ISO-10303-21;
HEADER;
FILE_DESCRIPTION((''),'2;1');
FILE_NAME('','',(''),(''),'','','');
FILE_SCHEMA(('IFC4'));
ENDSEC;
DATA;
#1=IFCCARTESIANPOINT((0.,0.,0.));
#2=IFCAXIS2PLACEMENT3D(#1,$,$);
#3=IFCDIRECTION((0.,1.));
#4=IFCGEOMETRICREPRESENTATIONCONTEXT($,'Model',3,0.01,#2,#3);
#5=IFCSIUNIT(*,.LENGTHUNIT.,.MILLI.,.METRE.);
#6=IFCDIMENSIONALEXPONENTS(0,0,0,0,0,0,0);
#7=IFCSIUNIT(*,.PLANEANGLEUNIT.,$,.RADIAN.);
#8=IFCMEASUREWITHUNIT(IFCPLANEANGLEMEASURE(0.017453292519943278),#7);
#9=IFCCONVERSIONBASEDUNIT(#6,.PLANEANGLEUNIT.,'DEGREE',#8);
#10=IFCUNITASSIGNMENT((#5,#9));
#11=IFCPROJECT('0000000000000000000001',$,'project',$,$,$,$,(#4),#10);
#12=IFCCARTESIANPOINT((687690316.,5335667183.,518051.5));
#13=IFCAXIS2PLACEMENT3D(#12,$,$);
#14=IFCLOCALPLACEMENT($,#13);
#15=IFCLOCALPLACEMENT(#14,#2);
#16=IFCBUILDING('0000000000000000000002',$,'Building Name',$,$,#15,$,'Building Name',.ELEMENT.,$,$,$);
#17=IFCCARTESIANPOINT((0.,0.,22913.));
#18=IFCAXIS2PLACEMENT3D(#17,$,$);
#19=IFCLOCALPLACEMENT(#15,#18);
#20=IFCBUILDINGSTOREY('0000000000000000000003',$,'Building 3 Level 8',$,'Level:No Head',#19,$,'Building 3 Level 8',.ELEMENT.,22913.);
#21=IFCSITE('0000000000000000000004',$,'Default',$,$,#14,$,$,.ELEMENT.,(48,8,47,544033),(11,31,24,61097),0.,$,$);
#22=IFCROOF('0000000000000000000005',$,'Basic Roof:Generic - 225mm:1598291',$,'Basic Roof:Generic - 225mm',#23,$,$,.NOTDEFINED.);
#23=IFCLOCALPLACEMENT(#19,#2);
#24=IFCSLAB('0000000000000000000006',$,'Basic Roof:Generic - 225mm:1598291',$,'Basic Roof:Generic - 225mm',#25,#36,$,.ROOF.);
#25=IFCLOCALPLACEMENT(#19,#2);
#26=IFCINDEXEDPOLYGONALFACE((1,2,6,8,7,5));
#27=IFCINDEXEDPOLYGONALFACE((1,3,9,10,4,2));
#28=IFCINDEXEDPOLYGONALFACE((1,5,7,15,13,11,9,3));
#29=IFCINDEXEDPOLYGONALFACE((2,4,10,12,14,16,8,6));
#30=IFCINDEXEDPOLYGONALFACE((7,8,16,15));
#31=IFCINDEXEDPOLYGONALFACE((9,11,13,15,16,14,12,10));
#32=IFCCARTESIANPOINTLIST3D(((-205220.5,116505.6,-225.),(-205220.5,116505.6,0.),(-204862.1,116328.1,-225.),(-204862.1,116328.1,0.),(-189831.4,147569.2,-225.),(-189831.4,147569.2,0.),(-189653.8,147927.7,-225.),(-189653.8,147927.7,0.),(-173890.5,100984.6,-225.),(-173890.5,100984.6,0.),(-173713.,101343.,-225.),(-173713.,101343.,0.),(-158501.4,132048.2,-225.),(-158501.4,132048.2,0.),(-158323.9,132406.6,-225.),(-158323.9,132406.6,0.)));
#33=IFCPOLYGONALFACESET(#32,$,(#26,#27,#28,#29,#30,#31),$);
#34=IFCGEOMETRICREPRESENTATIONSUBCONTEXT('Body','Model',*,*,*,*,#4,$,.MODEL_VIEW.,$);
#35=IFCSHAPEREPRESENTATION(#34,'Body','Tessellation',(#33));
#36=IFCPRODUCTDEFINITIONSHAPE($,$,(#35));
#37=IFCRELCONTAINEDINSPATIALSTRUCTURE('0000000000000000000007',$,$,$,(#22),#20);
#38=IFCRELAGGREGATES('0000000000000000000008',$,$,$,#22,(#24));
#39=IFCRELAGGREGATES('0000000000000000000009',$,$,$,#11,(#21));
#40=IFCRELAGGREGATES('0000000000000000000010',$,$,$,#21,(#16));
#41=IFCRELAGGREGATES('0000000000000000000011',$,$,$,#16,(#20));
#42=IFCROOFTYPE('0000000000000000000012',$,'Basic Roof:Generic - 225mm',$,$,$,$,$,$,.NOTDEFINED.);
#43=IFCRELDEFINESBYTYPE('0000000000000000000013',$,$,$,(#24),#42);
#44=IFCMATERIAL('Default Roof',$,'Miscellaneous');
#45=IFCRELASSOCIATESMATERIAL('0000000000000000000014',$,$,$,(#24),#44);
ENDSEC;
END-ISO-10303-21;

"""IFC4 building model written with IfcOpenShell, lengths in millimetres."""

from ifc_helpers import new_model, entity, si_unit, converted_unit, direction, frame, origin, place, context, subcontext, project, spatial, indexed_curve, outline, extrude, material, type_object, element, aggregate, save


model = new_model("IFC4")

# Units and contexts
model_context = context("Model", 3, precision=0.01, world=origin(), true_north=direction((0.0, 1.0)))
body_context = subcontext(model_context, "Body", "Model", "MODEL_VIEW")
ifc_project = project(units=[si_unit("LENGTHUNIT", "METRE", prefix="MILLI"), converted_unit("PLANEANGLEUNIT", "DEGREE", entity("IfcPlaneAngleMeasure", 0.017453292519943278), si_unit("PLANEANGLEUNIT", "RADIAN"), dimensions=[0, 0, 0, 0, 0, 0, 0])], contexts=[model_context])

# Site, building, storey
site_placement = place(None, frame((687690316.0, 5335667183.0, 518051.5)))
site = spatial("IfcSite", under=ifc_project, at=site_placement, Name="Default", CompositionType="ELEMENT", RefLatitude=(48, 8, 47, 544033), RefLongitude=(11, 31, 24, 61097), RefElevation=0.0)
building_placement = place(site_placement, origin())
building = spatial("IfcBuilding", under=site, at=building_placement, Name="Building Name", LongName="Building Name", CompositionType="ELEMENT")
storey_placement = place(building_placement, frame((0.0, 0.0, 22913.0)))
storey = spatial("IfcBuildingStorey", under=building, at=storey_placement, Name="Building 3 Level 8", ObjectType="Level:No Head", LongName="Building 3 Level 8", CompositionType="ELEMENT", Elevation=22913.0)

# Roof, slab
roof_placement = place(storey_placement, frame((-205220.5, 100984.6, -225.0)))
roof = element("IfcRoof", 1, at=roof_placement, inside=storey, Name="Basic Roof:Generic - 225mm:1598291", ObjectType="Basic Roof:Generic - 225mm", PredefinedType="NOTDEFINED")
ifc_material = material(Name="Default Roof", Category="Miscellaneous")
roof_type = type_object("IfcRoofType", Name="Basic Roof:Generic - 225mm", PredefinedType="NOTDEFINED")
slab_placement = place(roof_placement, origin())
slab = element("IfcSlab", 2, at=slab_placement, type_object=roof_type, material=ifc_material, Name="Basic Roof:Generic - 225mm:1598291", ObjectType="Basic Roof:Generic - 225mm", PredefinedType="ROOF", context=body_context, shape_type="SweptSolid", body=[
    extrude(outline(indexed_curve([(7881.7, -23471.5), (8059.2, -23113.1), (23270.7, 7592.1), (23448.3, 7950.5), (-7881.7, 23471.5), (-8059.2, 23113.1), (-23448.3, -7950.5), (-23089.9, -8128.1), (7881.7, -23471.5)], self_intersect=False)), frame((23448.3, 23471.5, 0.0)), (0.0, 0.0, 1.0), 225.0),
])
aggregate(roof, [slab])

save(model, "model.ifc")
